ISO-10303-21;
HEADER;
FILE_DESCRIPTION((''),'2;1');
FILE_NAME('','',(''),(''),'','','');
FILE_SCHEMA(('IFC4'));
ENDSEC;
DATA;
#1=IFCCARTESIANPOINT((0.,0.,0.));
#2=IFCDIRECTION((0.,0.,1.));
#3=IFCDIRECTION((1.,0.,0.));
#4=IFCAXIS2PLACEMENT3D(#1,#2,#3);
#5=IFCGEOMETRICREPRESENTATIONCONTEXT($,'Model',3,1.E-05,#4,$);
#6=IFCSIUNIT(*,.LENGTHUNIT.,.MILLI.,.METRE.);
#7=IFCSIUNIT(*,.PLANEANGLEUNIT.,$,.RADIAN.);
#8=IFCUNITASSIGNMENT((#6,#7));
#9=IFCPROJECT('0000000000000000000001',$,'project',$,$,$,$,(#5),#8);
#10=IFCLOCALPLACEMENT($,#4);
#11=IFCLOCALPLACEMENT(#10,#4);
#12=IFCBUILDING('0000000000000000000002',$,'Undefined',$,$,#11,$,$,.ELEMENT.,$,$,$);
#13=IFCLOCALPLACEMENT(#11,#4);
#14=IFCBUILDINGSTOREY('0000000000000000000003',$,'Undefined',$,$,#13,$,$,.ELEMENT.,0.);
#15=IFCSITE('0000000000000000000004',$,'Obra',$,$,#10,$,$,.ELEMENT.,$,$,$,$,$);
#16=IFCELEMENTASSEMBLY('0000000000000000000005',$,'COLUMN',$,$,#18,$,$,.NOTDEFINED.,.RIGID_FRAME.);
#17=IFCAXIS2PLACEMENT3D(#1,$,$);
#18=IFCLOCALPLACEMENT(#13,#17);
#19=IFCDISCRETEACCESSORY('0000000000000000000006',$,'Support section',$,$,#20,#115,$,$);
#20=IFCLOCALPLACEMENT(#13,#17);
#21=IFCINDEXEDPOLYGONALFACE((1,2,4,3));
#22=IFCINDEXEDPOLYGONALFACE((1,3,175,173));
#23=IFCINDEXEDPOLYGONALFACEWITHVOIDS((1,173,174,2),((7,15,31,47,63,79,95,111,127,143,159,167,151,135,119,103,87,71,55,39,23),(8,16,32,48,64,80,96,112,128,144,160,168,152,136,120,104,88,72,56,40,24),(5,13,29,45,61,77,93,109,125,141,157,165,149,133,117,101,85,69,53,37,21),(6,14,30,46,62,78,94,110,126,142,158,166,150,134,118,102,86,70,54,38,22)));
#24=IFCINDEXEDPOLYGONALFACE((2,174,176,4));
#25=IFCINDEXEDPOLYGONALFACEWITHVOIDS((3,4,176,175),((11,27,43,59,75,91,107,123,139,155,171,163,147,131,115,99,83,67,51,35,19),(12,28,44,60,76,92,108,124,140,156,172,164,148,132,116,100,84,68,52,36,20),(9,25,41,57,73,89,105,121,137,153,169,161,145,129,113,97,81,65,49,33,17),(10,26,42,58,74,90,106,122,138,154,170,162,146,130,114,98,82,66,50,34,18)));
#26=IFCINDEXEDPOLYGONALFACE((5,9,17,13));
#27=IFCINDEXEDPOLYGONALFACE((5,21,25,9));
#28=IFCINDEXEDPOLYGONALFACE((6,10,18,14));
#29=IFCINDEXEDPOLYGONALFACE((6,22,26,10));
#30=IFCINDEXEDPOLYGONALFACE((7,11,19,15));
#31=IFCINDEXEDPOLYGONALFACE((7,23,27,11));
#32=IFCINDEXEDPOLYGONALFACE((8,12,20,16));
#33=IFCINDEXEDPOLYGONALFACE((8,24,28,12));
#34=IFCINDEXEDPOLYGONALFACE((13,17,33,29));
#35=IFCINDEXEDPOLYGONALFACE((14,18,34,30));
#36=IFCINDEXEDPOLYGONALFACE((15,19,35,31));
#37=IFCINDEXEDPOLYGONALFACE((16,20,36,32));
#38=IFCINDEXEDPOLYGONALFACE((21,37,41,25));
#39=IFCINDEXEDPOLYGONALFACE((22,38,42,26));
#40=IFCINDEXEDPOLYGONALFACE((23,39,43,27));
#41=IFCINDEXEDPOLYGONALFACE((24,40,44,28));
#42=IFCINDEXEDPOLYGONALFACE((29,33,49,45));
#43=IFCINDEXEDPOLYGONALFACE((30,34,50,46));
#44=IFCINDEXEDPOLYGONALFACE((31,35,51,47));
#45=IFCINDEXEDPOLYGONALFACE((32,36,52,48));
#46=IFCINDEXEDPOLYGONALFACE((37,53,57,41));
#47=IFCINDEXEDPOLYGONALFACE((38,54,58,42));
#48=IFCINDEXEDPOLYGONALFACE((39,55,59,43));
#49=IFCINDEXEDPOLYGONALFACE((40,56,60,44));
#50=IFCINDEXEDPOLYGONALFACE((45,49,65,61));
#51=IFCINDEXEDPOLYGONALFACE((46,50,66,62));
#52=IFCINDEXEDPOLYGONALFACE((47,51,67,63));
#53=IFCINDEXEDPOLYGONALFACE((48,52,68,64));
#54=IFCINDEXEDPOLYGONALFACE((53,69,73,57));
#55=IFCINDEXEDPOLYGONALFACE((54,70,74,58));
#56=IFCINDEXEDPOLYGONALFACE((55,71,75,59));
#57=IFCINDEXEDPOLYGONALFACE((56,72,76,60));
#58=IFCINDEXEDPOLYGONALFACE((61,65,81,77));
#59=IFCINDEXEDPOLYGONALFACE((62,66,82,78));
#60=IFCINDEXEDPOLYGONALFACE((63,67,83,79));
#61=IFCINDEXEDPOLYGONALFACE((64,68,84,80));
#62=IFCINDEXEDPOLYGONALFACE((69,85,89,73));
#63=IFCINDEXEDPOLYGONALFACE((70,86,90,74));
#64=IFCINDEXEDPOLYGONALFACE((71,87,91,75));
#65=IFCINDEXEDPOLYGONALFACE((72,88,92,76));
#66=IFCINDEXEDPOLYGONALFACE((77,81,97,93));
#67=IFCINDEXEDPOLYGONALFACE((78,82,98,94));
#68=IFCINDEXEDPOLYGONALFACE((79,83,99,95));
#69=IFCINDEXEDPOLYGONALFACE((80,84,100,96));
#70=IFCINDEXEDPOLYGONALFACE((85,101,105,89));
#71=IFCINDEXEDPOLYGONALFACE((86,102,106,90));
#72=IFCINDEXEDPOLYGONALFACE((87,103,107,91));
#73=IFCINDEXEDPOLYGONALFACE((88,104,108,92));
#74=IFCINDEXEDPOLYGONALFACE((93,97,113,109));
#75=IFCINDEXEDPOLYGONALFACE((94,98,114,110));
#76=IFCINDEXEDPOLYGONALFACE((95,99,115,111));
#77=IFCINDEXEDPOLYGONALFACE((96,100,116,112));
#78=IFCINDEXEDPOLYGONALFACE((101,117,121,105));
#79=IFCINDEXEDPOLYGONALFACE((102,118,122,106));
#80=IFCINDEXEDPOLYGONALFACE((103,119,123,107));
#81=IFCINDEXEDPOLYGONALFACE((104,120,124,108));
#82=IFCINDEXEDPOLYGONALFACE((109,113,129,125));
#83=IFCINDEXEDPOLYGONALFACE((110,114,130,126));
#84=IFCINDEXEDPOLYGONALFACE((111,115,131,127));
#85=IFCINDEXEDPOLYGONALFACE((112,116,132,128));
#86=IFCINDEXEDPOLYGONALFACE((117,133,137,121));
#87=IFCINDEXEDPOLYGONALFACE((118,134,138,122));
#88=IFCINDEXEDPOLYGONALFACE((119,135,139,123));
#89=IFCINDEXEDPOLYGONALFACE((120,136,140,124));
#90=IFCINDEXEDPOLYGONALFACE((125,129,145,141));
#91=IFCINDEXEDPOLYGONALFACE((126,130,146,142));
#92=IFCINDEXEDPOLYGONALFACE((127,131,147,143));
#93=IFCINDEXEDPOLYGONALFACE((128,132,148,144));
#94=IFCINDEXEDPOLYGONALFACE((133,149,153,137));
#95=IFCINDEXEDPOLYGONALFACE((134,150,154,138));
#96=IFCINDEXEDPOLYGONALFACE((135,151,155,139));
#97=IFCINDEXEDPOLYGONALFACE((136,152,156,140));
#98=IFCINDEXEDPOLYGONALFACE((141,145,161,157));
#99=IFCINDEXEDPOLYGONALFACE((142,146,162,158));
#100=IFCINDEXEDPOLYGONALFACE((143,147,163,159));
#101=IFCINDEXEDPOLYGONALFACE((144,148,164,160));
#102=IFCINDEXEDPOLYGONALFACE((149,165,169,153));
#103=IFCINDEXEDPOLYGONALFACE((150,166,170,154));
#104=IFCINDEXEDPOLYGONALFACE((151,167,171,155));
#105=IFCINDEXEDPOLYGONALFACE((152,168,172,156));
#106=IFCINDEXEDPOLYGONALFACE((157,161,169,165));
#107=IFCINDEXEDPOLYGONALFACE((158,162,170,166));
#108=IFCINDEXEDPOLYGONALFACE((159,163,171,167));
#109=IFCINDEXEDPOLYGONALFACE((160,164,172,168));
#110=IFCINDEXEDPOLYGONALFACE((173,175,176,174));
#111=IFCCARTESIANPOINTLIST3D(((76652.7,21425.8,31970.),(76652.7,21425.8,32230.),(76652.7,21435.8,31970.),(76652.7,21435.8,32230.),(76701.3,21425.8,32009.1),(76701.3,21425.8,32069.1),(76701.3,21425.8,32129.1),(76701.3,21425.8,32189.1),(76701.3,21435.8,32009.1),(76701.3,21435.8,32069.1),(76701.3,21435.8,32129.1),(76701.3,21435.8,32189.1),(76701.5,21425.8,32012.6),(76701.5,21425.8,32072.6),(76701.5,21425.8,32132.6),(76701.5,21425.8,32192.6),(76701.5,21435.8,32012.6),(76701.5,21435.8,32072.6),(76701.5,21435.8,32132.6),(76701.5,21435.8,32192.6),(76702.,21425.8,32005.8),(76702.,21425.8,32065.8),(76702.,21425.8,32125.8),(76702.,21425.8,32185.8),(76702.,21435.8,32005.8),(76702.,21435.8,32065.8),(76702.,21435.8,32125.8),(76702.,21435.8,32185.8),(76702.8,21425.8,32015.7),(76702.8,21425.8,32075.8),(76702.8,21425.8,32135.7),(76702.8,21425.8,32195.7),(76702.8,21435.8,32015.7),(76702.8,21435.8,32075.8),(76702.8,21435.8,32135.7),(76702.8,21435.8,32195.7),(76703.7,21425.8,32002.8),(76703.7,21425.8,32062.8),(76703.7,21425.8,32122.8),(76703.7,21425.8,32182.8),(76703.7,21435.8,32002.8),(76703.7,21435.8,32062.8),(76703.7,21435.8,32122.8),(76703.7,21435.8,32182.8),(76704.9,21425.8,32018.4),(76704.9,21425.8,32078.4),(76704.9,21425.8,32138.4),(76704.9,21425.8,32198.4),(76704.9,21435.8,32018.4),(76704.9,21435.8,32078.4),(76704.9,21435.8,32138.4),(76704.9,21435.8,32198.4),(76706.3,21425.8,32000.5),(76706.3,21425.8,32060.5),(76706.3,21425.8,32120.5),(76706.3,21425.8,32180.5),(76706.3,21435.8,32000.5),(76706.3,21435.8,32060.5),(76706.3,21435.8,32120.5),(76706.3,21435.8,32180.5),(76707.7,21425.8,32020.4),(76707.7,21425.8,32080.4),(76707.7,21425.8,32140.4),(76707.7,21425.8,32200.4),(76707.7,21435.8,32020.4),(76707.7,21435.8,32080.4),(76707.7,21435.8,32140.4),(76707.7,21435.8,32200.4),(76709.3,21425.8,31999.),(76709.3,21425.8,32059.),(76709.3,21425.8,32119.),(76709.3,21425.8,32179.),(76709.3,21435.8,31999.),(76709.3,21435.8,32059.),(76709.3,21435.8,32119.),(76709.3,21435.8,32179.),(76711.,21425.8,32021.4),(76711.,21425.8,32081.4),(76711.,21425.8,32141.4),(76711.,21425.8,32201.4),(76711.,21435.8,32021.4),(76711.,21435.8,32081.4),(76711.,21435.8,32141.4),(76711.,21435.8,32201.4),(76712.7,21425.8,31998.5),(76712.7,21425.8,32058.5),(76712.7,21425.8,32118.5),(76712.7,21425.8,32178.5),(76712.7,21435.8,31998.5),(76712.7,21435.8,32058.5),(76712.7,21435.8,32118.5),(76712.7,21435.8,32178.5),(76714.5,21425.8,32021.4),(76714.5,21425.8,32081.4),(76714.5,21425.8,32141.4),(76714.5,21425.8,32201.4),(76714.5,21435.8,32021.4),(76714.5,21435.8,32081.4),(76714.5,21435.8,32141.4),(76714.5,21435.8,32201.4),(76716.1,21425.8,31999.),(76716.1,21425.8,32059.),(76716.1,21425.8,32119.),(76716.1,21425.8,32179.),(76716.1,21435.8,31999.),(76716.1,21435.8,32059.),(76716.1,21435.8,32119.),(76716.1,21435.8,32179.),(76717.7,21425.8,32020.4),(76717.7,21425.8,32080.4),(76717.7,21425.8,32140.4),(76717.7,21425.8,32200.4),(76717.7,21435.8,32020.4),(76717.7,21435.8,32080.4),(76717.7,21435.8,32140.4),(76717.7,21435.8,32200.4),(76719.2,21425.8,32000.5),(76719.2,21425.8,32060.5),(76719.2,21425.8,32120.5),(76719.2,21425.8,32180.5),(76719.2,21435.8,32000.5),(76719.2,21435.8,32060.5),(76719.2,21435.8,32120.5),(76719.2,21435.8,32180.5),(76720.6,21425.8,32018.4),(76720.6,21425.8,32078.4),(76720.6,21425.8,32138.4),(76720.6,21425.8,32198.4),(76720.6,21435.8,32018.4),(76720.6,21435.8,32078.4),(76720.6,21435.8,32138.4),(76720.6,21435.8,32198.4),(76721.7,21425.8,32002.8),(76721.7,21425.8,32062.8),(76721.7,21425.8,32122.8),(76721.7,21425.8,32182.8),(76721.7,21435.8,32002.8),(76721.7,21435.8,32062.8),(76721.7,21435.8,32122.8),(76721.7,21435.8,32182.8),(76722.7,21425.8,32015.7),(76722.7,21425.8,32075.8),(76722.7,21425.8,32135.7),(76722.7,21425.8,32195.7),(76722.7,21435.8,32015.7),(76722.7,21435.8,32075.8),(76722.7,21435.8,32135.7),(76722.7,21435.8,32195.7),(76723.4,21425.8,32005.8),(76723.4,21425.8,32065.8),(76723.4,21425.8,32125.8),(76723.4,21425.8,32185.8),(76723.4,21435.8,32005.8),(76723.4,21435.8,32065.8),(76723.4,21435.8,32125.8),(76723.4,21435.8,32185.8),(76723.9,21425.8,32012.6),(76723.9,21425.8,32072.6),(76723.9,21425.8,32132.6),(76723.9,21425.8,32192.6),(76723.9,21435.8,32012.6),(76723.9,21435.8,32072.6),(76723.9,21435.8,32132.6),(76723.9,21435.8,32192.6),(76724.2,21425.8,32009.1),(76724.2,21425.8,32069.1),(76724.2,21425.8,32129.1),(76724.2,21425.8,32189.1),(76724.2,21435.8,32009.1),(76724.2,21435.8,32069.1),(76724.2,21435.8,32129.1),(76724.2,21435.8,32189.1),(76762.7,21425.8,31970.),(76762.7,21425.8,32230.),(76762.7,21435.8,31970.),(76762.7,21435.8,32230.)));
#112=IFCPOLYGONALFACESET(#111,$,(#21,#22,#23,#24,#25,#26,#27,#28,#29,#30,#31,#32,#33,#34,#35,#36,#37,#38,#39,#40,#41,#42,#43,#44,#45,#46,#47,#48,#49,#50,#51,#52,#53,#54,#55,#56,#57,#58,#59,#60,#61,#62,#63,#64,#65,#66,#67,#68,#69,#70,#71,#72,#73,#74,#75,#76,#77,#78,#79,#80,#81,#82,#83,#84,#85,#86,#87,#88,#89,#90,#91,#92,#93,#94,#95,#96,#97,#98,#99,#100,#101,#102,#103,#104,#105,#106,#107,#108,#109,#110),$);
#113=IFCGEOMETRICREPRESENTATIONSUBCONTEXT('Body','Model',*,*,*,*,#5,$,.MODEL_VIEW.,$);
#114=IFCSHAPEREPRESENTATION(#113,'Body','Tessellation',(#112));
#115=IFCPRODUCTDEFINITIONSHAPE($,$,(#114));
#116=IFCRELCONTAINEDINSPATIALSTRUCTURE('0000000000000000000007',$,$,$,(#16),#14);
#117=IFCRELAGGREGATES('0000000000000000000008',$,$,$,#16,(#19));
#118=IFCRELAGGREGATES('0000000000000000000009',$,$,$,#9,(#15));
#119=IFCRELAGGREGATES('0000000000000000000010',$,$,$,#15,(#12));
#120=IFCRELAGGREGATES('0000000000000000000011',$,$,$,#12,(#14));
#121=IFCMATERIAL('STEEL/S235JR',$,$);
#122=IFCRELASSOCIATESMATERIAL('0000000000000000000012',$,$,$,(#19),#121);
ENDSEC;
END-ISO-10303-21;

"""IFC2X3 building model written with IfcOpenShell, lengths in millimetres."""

from ifc_helpers import new_model, si_unit, frame, origin_with_axes, origin_2d_with_axis, place, context, subcontext, project, spatial, rectangle, circle, extrude, source, transform, mapped, material, element, aggregate, save


model = new_model("IFC2X3")

# Units and contexts
model_context = context("Model", 3, precision=1e-05, world=origin_with_axes())
body_context = subcontext(model_context, "Body", "Model", "MODEL_VIEW")
ifc_project = project(units=[si_unit("LENGTHUNIT", "METRE", prefix="MILLI"), si_unit("PLANEANGLEUNIT", "RADIAN")], contexts=[model_context])

# Site, building, storey
site_placement = place(None, origin_with_axes())
site = spatial("IfcSite", under=ifc_project, at=site_placement, Name="Obra", CompositionType="ELEMENT")
building_placement = place(site_placement, origin_with_axes())
building = spatial("IfcBuilding", under=site, at=building_placement, Name="Undefined", CompositionType="ELEMENT")
storey_placement = place(building_placement, origin_with_axes())
storey = spatial("IfcBuildingStorey", under=building, at=storey_placement, Name="Undefined", CompositionType="ELEMENT", Elevation=0.0)

# Shared definitions
ifc_material_1 = material(Name="STEEL/S235JR")

# Element assembly, discrete accessory, opening
assembly_1_placement = place(storey_placement, origin_with_axes())
assembly_1 = element("IfcElementAssembly", 1, at=assembly_1_placement, inside=storey, Name="COLUMN", AssemblyPlace="NOTDEFINED", PredefinedType="RIGID_FRAME")
shared_shape_1 = source(origin_with_axes(), body_context, "Body", "SweptSolid", [
    extrude(circle(Radius=11.5, at=origin_2d_with_axis()), frame((0.0, -14.4, 0.0), z_axis=(0.0, 1.0, 0.0), x_axis=(1.0, 0.0, 0.0)), (0.0, 0.0, 1.0), 10.2),
])
discrete_accessory_1_placement = place(assembly_1_placement, frame((76707.7, 21430.8, 31970.0), z_axis=(0.0, 0.0, 1.0), x_axis=(-1.0, 0.0, 0.0)))
discrete_accessory_1 = element("IfcDiscreteAccessory", 2, at=discrete_accessory_1_placement, material=ifc_material_1, Name="Support section", context=body_context, shape_type="SweptSolid", body=[
    extrude(rectangle(XDim=10.0, YDim=110.0, at=origin_2d_with_axis()), frame((0.0, 0.0, 260.0), z_axis=(0.0, 0.0, -1.0), x_axis=(0.0, 1.0, 0.0)), (0.0, 0.0, 1.0), 260.0),
])
opening_1_placement = place(assembly_1_placement, frame((76662.7, 21440.1, 32300.0), z_axis=(1.0, 0.0, 0.0), x_axis=(0.0, 0.0, -1.0)))
element("IfcOpeningElement", 3, at=opening_1_placement, cuts=discrete_accessory_1, ObjectType="Opening", context=body_context, shape_type="MappedRepresentation", body=[
    mapped(shared_shape_1, transform((110.0, 0.0, 50.0))),
    mapped(shared_shape_1, transform((170.0, 0.0, 50.0))),
    mapped(shared_shape_1, transform((230.0, 0.0, 50.0))),
    mapped(shared_shape_1, transform((290.0, 0.0, 50.0))),
])
aggregate(assembly_1, [discrete_accessory_1])

save(model, "model.ifc")
